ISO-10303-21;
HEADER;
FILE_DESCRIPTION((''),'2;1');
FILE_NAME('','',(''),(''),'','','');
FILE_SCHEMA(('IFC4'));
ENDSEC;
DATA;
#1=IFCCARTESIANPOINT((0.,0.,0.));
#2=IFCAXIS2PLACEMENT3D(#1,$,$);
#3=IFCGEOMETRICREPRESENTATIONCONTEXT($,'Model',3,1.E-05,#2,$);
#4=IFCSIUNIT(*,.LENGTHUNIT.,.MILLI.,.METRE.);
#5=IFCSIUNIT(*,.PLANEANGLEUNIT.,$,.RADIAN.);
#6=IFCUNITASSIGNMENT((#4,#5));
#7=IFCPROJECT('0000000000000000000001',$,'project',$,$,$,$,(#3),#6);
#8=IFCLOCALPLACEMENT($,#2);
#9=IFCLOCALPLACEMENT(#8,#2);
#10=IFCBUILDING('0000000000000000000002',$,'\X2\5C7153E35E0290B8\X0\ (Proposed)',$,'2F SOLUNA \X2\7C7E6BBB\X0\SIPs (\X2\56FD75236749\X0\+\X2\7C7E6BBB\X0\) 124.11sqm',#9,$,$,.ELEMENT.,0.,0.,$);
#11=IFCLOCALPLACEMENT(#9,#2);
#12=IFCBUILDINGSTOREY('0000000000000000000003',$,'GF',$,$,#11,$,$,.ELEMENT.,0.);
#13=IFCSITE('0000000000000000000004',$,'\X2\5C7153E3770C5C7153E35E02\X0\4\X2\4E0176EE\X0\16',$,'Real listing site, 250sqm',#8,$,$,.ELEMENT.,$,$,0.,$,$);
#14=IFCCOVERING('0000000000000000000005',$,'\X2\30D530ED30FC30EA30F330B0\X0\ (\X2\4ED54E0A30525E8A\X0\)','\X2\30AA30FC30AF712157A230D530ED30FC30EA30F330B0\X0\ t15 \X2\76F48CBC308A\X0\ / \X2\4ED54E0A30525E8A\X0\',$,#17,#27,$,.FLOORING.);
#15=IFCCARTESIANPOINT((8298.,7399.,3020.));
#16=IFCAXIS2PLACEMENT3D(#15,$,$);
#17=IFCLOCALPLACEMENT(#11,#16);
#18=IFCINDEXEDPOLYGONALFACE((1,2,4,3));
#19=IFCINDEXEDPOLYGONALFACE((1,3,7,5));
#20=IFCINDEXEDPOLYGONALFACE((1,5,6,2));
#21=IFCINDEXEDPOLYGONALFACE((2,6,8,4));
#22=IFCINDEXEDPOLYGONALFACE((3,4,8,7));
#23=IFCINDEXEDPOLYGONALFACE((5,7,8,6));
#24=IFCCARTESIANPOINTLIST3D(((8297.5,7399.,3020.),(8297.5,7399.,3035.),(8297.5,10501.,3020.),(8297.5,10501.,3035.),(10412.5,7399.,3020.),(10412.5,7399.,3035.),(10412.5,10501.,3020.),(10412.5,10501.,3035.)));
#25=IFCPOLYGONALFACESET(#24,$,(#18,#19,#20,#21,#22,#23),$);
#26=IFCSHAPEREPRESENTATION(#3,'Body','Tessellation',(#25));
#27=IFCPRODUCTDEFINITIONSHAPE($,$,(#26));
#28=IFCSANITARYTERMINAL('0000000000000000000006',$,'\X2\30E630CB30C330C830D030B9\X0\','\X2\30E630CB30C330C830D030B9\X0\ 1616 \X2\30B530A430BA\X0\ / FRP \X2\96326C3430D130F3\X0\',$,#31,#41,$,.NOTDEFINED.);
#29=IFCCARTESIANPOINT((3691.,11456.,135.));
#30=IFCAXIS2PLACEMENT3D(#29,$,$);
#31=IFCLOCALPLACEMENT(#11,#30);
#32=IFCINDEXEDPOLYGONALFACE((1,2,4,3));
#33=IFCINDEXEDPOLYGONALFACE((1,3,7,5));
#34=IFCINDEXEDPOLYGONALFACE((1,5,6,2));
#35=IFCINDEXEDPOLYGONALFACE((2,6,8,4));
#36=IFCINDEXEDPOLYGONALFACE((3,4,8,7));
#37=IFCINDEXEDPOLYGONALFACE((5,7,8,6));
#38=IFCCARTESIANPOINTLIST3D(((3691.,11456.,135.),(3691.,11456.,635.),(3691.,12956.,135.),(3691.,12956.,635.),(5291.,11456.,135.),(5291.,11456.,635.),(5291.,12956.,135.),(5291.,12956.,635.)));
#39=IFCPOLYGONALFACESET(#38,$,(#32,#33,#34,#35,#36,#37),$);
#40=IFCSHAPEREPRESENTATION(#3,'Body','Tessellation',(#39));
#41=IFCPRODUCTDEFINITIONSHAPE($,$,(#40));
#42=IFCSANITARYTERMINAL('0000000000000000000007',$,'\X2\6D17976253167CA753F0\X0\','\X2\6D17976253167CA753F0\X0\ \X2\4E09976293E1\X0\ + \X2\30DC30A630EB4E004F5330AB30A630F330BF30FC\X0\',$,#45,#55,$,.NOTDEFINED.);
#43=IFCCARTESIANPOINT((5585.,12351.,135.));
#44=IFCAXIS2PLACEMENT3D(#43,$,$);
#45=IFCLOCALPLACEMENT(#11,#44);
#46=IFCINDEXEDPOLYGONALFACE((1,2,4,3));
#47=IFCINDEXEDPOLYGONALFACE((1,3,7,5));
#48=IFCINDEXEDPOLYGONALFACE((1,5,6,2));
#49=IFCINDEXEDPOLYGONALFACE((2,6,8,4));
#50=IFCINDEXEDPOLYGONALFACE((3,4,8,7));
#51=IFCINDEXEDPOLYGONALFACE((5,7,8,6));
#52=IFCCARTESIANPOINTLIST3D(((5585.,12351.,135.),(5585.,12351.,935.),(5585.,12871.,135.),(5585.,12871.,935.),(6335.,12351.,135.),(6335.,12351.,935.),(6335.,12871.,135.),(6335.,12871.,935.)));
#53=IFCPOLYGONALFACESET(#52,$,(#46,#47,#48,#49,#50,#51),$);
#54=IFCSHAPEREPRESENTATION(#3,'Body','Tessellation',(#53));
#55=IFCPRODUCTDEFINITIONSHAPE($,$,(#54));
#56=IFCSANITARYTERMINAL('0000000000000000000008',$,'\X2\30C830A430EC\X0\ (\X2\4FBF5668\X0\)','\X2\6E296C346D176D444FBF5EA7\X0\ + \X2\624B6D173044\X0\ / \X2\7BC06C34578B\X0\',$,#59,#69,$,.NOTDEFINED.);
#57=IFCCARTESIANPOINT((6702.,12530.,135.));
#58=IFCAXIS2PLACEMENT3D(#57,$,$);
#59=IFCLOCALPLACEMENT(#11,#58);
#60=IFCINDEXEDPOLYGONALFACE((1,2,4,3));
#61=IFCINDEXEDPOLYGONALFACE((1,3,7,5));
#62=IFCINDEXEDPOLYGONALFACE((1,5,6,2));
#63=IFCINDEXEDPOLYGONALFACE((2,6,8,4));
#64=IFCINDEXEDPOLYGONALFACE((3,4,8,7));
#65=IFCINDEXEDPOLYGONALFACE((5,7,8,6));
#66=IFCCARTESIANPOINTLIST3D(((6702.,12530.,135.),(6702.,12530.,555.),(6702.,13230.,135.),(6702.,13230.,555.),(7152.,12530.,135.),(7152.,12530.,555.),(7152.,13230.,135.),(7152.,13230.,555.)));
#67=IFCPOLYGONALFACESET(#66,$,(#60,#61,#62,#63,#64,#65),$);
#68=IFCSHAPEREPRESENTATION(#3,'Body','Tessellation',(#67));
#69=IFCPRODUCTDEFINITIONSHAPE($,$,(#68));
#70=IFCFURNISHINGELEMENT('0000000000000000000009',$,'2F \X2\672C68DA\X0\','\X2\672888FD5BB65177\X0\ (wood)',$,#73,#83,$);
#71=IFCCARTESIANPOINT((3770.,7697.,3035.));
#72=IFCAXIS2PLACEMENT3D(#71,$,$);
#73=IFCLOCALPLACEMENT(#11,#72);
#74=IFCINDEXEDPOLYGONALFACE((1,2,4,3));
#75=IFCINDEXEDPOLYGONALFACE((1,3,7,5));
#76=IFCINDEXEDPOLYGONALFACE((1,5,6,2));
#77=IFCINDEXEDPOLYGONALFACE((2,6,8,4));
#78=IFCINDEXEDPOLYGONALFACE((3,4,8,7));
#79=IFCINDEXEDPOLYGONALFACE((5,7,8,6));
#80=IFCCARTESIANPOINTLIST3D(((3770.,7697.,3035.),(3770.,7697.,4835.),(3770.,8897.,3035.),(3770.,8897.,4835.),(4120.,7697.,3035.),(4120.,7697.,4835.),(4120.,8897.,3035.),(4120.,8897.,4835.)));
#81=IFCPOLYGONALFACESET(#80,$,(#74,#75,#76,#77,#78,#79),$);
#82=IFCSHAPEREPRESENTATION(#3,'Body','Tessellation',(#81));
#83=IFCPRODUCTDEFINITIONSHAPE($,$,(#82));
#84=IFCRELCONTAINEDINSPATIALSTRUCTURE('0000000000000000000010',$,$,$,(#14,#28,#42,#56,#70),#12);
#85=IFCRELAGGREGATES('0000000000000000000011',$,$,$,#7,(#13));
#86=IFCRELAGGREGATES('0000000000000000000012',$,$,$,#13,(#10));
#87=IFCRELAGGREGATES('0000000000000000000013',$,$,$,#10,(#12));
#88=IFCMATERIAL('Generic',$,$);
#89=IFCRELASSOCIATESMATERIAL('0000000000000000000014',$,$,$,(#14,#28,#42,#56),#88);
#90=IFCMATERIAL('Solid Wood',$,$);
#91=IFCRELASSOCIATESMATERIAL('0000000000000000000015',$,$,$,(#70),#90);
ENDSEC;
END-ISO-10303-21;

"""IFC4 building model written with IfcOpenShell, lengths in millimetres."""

from ifc_helpers import new_model, si_unit, frame, frame_2d, origin, place, context, project, spatial, rectangle, extrude, material, element, save


model = new_model("IFC4")

# Units and contexts
model_context = context("Model", 3, precision=1e-05, world=origin())
ifc_project = project(units=[si_unit("LENGTHUNIT", "METRE", prefix="MILLI"), si_unit("PLANEANGLEUNIT", "RADIAN")], contexts=[model_context])

# Site, building, storey
site_placement = place(None, origin())
site = spatial("IfcSite", under=ifc_project, at=site_placement, Name="山口県山口市4丁目16", ObjectType="Real listing site, 250sqm", CompositionType="ELEMENT", RefElevation=0.0)
building_placement = place(site_placement, origin())
building = spatial("IfcBuilding", under=site, at=building_placement, Name="山口市邸 (Proposed)", ObjectType="2F SOLUNA 籾殻SIPs (国産杉+籾殻) 124.11sqm", CompositionType="ELEMENT", ElevationOfRefHeight=0.0, ElevationOfTerrain=0.0)
storey_placement = place(building_placement, origin())
storey = spatial("IfcBuildingStorey", under=building, at=storey_placement, Name="GF", CompositionType="ELEMENT", Elevation=0.0)

# Shared definitions
ifc_material_1 = material(Name="Solid Wood")

# Shared definitions
ifc_material_2 = material(Name="Generic")

# Covering
covering_1_placement = place(storey_placement, frame((8298.0, 7399.0, 3020.0)))
element("IfcCovering", 1, at=covering_1_placement, inside=storey, material=ifc_material_2, Name="フローリング (仕上げ床)", Description="オーク無垢フローリング t15 直貼り / 仕上げ床", PredefinedType="FLOORING", context=model_context, shape_type="SweptSolid", body=[
    extrude(rectangle(XDim=2115.0, YDim=3102.0, at=frame_2d((1057.0, 1551.0))), frame((8298.0, 7399.0, 3020.0)), (0.0, 0.0, 1.0), 15.0),
])

# Sanitary terminals
sanitary_terminal_1_placement = place(storey_placement, frame((3691.0, 11456.0, 135.0)))
element("IfcSanitaryTerminal", 2, at=sanitary_terminal_1_placement, inside=storey, material=ifc_material_2, Name="ユニットバス", Description="ユニットバス 1616 サイズ / FRP 防水パン", PredefinedType="NOTDEFINED", context=model_context, shape_type="SweptSolid", body=[
    extrude(rectangle(XDim=1600.0, YDim=1500.0, at=frame_2d((800.0, 750.0))), frame((3691.0, 11456.0, 135.0)), (0.0, 0.0, 1.0), 500.0),
])
sanitary_terminal_2_placement = place(storey_placement, frame((5585.0, 12351.0, 135.0)))
element("IfcSanitaryTerminal", 3, at=sanitary_terminal_2_placement, inside=storey, material=ifc_material_2, Name="洗面化粧台", Description="洗面化粧台 三面鏡 + ボウル一体カウンター", PredefinedType="NOTDEFINED", context=model_context, shape_type="SweptSolid", body=[
    extrude(rectangle(XDim=750.0, YDim=520.0, at=frame_2d((375.0, 260.0))), frame((5585.0, 12351.0, 135.0)), (0.0, 0.0, 1.0), 800.0),
])
sanitary_terminal_3_placement = place(storey_placement, frame((6702.0, 12530.0, 135.0)))
element("IfcSanitaryTerminal", 4, at=sanitary_terminal_3_placement, inside=storey, material=ifc_material_2, Name="トイレ (便器)", Description="温水洗浄便座 + 手洗い / 節水型", PredefinedType="NOTDEFINED", context=model_context, shape_type="SweptSolid", body=[
    extrude(rectangle(XDim=450.0, YDim=700.0, at=frame_2d((225.0, 350.0))), frame((6702.0, 12530.0, 135.0)), (0.0, 0.0, 1.0), 420.0),
])

# Furnishing element
furnishing_placement = place(storey_placement, frame((3770.0, 7697.0, 3035.0)))
element("IfcFurnishingElement", 5, at=furnishing_placement, inside=storey, material=ifc_material_1, Name="2F 本棚", Description="木製家具 (wood)", context=model_context, shape_type="SweptSolid", body=[
    extrude(rectangle(XDim=350.0, YDim=1200.0, at=frame_2d((175.0, 600.0))), frame((3770.0, 7697.0, 3035.0)), (0.0, 0.0, 1.0), 1800.0),
])

save(model, "model.ifc")
